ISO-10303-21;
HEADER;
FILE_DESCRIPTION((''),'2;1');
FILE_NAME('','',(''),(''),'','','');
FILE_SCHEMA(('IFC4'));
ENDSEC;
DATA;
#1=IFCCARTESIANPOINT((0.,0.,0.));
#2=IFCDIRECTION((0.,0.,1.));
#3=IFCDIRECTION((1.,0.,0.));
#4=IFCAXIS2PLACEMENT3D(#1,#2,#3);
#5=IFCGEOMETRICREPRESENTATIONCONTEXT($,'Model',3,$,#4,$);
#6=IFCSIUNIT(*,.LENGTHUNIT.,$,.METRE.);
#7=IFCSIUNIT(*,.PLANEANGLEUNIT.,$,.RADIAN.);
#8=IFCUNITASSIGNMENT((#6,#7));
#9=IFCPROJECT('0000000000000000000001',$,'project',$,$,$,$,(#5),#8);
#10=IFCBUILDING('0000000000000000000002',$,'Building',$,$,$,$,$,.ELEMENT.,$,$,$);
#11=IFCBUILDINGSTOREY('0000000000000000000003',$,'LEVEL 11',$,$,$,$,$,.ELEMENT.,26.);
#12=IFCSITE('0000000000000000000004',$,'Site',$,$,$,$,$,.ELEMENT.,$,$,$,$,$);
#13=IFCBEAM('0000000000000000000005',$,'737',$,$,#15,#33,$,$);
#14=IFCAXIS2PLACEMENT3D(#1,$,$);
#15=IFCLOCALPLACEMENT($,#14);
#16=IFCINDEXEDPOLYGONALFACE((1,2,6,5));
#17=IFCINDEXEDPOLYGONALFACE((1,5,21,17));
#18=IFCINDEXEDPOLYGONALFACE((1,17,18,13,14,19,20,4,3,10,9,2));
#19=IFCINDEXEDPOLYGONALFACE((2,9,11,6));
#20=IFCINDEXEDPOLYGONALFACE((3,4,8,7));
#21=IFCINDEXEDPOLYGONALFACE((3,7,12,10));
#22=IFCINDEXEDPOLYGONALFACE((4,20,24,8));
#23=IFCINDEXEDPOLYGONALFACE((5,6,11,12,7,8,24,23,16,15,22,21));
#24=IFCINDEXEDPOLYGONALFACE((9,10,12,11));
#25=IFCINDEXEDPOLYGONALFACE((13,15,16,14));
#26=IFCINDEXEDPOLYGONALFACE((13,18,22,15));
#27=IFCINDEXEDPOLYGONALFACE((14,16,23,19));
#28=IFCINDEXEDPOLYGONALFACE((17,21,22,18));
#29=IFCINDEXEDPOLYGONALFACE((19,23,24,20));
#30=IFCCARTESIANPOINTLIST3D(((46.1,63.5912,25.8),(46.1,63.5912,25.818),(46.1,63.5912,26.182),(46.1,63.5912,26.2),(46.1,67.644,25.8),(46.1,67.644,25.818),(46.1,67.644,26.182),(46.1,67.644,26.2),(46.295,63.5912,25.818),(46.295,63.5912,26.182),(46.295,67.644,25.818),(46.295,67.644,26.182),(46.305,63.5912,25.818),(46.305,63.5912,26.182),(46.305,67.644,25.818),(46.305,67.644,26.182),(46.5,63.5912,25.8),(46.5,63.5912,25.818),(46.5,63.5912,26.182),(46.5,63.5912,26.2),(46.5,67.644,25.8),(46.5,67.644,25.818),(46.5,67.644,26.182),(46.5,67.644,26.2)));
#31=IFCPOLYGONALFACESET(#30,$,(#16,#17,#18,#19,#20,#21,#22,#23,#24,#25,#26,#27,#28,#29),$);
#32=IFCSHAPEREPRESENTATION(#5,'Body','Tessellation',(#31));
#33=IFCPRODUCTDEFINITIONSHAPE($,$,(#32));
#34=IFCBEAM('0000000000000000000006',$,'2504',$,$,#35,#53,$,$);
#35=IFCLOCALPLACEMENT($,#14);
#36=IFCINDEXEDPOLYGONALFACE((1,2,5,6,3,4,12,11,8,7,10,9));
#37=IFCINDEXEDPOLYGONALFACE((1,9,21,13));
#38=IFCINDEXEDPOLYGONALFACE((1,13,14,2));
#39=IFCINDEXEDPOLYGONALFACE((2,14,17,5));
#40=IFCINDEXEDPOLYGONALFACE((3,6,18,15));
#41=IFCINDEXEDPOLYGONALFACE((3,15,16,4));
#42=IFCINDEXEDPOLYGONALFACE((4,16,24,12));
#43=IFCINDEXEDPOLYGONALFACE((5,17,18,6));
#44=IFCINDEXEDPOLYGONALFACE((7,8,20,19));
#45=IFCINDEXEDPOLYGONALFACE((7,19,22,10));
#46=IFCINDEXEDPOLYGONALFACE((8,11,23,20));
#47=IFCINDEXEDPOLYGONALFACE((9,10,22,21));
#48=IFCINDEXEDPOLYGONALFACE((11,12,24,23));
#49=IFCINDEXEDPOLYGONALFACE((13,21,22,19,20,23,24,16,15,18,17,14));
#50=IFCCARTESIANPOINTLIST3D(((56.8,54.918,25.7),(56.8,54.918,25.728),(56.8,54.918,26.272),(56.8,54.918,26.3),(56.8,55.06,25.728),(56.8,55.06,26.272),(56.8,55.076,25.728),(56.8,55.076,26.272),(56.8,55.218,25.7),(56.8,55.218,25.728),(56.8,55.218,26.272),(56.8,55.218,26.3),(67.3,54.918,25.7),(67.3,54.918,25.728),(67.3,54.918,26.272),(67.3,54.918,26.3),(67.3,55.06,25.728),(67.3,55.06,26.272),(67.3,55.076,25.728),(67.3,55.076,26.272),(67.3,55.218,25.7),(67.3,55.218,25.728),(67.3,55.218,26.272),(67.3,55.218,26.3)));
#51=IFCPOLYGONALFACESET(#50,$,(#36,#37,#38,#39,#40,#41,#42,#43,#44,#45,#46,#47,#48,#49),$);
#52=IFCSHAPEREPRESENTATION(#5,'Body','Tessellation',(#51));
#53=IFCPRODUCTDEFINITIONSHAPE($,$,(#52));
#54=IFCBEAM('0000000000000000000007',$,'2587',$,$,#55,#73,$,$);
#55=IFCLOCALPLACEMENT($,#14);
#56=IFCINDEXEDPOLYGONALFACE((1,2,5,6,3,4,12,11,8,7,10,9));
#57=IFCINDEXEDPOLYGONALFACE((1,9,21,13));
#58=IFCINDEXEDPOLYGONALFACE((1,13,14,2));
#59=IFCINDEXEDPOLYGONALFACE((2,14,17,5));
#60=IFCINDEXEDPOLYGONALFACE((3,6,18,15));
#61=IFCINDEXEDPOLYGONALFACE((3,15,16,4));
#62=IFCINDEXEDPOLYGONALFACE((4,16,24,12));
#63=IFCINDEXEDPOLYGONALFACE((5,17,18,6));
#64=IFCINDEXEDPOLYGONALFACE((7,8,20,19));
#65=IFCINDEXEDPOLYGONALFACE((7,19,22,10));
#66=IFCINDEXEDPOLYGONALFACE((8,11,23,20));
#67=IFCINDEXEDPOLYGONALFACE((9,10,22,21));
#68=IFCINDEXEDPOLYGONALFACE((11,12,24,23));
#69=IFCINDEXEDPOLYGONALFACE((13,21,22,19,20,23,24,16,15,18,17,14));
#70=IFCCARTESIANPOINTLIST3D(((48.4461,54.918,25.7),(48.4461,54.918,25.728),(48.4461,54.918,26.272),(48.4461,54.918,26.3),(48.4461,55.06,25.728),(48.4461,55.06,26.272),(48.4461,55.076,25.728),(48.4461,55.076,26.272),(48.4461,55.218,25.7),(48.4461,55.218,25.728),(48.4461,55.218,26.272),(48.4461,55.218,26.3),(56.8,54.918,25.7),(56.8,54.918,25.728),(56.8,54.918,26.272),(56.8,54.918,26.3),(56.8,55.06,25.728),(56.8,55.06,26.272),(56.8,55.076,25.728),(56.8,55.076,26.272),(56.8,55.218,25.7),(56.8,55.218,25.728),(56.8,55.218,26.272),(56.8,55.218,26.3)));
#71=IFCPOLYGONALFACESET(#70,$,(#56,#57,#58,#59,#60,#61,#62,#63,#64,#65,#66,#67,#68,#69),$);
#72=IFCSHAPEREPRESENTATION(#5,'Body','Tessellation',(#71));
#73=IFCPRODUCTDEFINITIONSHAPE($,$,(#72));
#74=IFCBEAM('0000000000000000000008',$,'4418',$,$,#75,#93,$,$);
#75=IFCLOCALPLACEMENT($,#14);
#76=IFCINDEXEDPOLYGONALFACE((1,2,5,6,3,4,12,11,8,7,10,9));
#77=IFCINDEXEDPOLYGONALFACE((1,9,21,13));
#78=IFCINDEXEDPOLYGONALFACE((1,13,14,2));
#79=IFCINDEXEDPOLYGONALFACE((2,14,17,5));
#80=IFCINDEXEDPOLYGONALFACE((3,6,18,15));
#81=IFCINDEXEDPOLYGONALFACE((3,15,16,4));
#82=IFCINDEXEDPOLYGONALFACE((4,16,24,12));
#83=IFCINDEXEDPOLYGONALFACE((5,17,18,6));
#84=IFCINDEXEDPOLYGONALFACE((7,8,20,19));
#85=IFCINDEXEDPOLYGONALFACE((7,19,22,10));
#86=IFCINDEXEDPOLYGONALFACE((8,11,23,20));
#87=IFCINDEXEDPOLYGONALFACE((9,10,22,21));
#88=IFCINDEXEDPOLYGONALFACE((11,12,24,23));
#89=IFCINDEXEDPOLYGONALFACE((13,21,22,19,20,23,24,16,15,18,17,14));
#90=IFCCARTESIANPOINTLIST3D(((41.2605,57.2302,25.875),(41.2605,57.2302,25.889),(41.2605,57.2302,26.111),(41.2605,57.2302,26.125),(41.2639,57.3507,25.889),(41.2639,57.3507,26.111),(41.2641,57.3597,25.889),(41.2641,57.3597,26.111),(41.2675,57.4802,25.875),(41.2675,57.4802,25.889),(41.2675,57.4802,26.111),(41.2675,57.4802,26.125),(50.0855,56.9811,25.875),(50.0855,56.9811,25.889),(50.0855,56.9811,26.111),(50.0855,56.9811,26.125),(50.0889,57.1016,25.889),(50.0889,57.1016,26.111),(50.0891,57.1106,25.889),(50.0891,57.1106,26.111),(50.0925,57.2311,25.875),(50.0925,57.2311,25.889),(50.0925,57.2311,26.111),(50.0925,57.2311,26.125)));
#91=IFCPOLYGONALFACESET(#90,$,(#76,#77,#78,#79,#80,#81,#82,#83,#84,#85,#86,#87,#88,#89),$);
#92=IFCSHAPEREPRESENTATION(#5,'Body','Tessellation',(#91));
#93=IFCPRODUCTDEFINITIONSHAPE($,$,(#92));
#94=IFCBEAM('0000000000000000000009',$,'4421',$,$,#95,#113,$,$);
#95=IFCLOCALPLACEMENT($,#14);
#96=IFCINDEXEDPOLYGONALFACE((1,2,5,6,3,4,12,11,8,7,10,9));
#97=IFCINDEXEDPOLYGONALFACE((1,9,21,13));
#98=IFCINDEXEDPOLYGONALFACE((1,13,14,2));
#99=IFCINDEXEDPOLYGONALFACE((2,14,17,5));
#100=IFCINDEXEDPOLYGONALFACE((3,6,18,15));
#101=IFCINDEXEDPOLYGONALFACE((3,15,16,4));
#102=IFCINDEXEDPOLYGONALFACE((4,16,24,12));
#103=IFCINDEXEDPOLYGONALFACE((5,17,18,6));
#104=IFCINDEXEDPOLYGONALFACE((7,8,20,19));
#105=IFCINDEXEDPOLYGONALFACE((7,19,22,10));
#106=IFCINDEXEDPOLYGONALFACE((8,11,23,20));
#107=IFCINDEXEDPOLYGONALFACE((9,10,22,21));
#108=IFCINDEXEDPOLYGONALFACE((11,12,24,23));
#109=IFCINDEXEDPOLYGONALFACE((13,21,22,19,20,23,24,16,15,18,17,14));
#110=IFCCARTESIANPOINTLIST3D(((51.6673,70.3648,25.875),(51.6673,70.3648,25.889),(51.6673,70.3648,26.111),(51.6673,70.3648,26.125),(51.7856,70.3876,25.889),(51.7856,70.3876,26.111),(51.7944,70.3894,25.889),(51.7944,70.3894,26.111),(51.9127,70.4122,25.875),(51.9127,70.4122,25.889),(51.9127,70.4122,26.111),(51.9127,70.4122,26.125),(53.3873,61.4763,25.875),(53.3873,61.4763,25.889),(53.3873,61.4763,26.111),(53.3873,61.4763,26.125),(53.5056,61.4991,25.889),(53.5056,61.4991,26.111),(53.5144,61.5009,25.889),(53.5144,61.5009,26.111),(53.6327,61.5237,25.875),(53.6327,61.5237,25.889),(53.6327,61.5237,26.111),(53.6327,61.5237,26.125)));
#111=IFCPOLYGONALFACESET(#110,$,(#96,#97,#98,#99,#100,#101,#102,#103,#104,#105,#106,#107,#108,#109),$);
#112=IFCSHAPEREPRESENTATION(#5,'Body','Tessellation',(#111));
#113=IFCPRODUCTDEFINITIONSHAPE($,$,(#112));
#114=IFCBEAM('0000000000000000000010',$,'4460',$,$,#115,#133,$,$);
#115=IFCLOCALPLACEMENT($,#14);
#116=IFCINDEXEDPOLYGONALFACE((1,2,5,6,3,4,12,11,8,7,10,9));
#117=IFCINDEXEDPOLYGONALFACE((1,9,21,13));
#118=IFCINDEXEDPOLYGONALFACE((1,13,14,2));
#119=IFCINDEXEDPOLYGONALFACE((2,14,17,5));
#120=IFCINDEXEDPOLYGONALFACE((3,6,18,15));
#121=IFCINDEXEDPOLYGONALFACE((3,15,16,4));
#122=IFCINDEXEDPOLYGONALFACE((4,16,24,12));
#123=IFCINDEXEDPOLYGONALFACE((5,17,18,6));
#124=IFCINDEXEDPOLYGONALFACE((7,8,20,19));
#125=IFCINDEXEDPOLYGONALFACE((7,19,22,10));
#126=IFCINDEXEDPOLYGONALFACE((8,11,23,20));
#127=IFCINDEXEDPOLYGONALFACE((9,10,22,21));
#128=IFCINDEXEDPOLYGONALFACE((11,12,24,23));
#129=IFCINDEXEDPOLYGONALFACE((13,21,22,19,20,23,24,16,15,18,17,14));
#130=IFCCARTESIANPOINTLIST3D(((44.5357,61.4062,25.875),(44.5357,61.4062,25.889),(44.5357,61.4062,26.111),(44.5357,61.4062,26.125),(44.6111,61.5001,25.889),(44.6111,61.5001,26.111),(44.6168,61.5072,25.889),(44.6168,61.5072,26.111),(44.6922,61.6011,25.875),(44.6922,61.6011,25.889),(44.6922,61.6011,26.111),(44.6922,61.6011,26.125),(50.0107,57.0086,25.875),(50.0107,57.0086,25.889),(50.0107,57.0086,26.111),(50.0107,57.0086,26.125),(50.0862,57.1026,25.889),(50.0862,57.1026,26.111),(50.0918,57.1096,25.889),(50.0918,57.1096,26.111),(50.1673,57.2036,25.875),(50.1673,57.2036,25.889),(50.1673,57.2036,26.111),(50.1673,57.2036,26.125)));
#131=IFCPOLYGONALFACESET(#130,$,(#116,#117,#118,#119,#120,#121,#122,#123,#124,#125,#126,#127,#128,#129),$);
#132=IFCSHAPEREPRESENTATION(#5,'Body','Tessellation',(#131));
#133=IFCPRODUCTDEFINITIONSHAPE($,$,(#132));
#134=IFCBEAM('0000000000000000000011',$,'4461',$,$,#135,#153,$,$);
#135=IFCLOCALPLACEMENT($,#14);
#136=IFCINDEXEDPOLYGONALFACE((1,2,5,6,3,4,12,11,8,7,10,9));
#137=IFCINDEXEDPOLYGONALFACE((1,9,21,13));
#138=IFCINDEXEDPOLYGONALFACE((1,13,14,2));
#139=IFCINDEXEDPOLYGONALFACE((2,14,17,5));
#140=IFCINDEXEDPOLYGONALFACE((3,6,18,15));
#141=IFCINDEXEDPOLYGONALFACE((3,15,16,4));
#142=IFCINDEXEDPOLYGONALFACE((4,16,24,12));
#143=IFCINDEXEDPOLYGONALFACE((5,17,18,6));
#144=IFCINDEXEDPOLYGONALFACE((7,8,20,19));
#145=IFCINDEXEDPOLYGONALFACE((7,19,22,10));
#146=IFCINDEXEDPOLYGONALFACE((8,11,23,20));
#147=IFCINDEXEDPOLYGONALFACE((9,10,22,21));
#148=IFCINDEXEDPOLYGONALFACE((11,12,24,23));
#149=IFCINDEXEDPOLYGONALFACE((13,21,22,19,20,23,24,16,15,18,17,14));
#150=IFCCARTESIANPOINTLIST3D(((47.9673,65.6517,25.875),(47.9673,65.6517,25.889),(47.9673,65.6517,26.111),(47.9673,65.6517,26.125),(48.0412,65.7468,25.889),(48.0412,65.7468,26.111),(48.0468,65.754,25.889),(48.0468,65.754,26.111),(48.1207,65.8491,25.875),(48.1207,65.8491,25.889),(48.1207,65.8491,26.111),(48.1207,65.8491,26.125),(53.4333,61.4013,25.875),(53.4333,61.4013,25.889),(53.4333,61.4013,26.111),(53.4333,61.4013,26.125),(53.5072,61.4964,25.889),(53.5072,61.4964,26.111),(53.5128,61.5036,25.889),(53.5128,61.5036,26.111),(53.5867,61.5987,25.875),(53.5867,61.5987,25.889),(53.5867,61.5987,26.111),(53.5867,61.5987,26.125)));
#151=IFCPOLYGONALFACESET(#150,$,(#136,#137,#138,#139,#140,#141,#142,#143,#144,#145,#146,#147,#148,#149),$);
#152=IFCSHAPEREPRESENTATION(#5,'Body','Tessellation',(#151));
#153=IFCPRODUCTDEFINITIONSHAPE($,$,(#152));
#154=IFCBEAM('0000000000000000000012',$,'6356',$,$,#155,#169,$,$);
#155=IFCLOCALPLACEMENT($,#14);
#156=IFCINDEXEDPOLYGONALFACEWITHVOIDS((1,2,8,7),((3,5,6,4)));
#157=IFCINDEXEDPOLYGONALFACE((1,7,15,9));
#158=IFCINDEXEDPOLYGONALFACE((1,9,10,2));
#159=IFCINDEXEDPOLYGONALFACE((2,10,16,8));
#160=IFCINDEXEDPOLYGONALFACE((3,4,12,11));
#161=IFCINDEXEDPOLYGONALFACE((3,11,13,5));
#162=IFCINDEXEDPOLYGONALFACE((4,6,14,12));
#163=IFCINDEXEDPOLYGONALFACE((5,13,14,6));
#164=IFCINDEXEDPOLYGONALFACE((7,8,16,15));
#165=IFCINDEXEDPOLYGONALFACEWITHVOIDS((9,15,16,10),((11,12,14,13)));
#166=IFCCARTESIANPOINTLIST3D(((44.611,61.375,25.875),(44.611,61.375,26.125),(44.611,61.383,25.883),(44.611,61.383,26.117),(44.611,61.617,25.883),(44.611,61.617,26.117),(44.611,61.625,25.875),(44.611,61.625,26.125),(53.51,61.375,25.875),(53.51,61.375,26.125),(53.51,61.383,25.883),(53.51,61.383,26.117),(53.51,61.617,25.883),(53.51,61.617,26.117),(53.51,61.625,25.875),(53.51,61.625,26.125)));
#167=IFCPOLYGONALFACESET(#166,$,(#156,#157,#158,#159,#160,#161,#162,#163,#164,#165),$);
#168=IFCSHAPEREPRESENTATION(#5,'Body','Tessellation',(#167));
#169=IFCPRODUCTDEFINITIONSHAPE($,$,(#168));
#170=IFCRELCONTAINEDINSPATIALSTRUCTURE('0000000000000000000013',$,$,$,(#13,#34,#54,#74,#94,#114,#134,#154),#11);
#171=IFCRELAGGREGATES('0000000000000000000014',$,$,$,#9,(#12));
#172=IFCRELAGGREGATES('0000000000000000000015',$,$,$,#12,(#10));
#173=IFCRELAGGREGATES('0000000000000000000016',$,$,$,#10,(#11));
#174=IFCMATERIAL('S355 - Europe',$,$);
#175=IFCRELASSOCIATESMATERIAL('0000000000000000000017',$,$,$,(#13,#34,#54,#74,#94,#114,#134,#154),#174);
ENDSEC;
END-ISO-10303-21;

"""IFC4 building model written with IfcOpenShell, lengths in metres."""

from ifc_helpers import new_model, si_unit, frame, origin_with_axes, origin_2d_with_axis, place, context, project, spatial, hollow_rectangle, i_section, extrude, material, material_profile, profile_set, profile_usage, element, save


model = new_model("IFC4")

# Units and contexts
model_context = context("Model", 3, world=origin_with_axes())
ifc_project = project(units=[si_unit("LENGTHUNIT", "METRE"), si_unit("PLANEANGLEUNIT", "RADIAN")], contexts=[model_context])

# Site, building, storey
site = spatial("IfcSite", under=ifc_project, Name="Site", CompositionType="ELEMENT")
building = spatial("IfcBuilding", under=site, Name="Building", CompositionType="ELEMENT")
storey = spatial("IfcBuildingStorey", under=building, Name="LEVEL 11", CompositionType="ELEMENT", Elevation=26.0)

# Shared definitions
ifc_material = material(Name="S355 - Europe")

# Beams
ifc_material_profile_1 = material_profile(ifc_material, i_section(OverallWidth=0.4, OverallDepth=0.4, WebThickness=0.01, FlangeThickness=0.018, at=origin_2d_with_axis()))
ifc_profile_set_1 = profile_set([ifc_material_profile_1])
ifc_profile_usage_1 = profile_usage(ifc_profile_set_1, cardinal=10)
beam_1_placement = place(None, frame((46.3, 63.5912, 26.0), z_axis=(0.0, 1.0, 0.0), x_axis=(-1.0, 0.0, 0.0)))
element("IfcBeam", 1, at=beam_1_placement, inside=storey, material=ifc_profile_usage_1, Name="737", context=model_context, shape_type="SweptSolid", body=[
    extrude(i_section(OverallWidth=0.4, OverallDepth=0.4, WebThickness=0.01, FlangeThickness=0.018, at=origin_2d_with_axis()), origin_with_axes(), (0.0, 0.0, 1.0), 4.0528),
])
ifc_material_profile_2 = material_profile(ifc_material, i_section(OverallWidth=0.3, OverallDepth=0.6, WebThickness=0.016, FlangeThickness=0.028, at=origin_2d_with_axis()))
ifc_profile_set_2 = profile_set([ifc_material_profile_2])
ifc_profile_usage_2 = profile_usage(ifc_profile_set_2, cardinal=10)
beam_2_placement = place(None, frame((56.8, 55.068, 26.0), z_axis=(1.0, 0.0, 0.0), x_axis=(0.0, 1.0, 0.0)))
element("IfcBeam", 2, at=beam_2_placement, inside=storey, material=ifc_profile_usage_2, Name="2504", context=model_context, shape_type="SweptSolid", body=[
    extrude(i_section(OverallWidth=0.3, OverallDepth=0.6, WebThickness=0.016, FlangeThickness=0.028, at=origin_2d_with_axis()), origin_with_axes(), (0.0, 0.0, 1.0), 10.5),
])
ifc_material_profile_3 = material_profile(ifc_material, i_section(OverallWidth=0.3, OverallDepth=0.6, WebThickness=0.016, FlangeThickness=0.028, at=origin_2d_with_axis()))
ifc_profile_set_3 = profile_set([ifc_material_profile_3])
ifc_profile_usage_3 = profile_usage(ifc_profile_set_3, cardinal=10)
beam_3_placement = place(None, frame((48.4461, 55.068, 26.0), z_axis=(1.0, 0.0, 0.0), x_axis=(0.0, 1.0, 0.0)))
element("IfcBeam", 3, at=beam_3_placement, inside=storey, material=ifc_profile_usage_3, Name="2587", context=model_context, shape_type="SweptSolid", body=[
    extrude(i_section(OverallWidth=0.3, OverallDepth=0.6, WebThickness=0.016, FlangeThickness=0.028, at=origin_2d_with_axis()), origin_with_axes(), (0.0, 0.0, 1.0), 8.3539),
])
ifc_material_profile_4 = material_profile(ifc_material, i_section(OverallWidth=0.25, OverallDepth=0.25, WebThickness=0.009, FlangeThickness=0.014, at=origin_2d_with_axis()))
ifc_profile_set_4 = profile_set([ifc_material_profile_4])
ifc_profile_usage_4 = profile_usage(ifc_profile_set_4, cardinal=10)
beam_4_placement = place(None, frame((41.264, 57.3552, 26.0), z_axis=(0.999602, -0.028215, 0.0), x_axis=(0.028215, 0.999602, 0.0)))
element("IfcBeam", 4, at=beam_4_placement, inside=storey, material=ifc_profile_usage_4, Name="4418", context=model_context, shape_type="SweptSolid", body=[
    extrude(i_section(OverallWidth=0.25, OverallDepth=0.25, WebThickness=0.009, FlangeThickness=0.014, at=origin_2d_with_axis()), origin_with_axes(), (0.0, 0.0, 1.0), 8.8285),
])
ifc_material_profile_5 = material_profile(ifc_material, i_section(OverallWidth=0.25, OverallDepth=0.25, WebThickness=0.009, FlangeThickness=0.014, at=origin_2d_with_axis()))
ifc_profile_set_5 = profile_set([ifc_material_profile_5])
ifc_profile_usage_5 = profile_usage(ifc_profile_set_5, cardinal=10)
beam_5_placement = place(None, frame((53.51, 61.5, 26.0), z_axis=(-0.189984, 0.981787, 0.0), x_axis=(-0.981787, -0.189984, 0.0)))
element("IfcBeam", 5, at=beam_5_placement, inside=storey, material=ifc_profile_usage_5, Name="4421", context=model_context, shape_type="SweptSolid", body=[
    extrude(i_section(OverallWidth=0.25, OverallDepth=0.25, WebThickness=0.009, FlangeThickness=0.014, at=origin_2d_with_axis()), origin_with_axes(), (0.0, 0.0, 1.0), 9.0534),
])
ifc_material_profile_6 = material_profile(ifc_material, i_section(OverallWidth=0.25, OverallDepth=0.25, WebThickness=0.009, FlangeThickness=0.014, at=origin_2d_with_axis()))
ifc_profile_set_6 = profile_set([ifc_material_profile_6])
ifc_profile_usage_6 = profile_usage(ifc_profile_set_6, cardinal=10)
beam_6_placement = place(None, frame((50.089, 57.1061, 26.0), z_axis=(-0.779651, 0.626214, 0.0), x_axis=(-0.626214, -0.779651, 0.0)))
element("IfcBeam", 6, at=beam_6_placement, inside=storey, material=ifc_profile_usage_6, Name="4460", context=model_context, shape_type="SweptSolid", body=[
    extrude(i_section(OverallWidth=0.25, OverallDepth=0.25, WebThickness=0.009, FlangeThickness=0.014, at=origin_2d_with_axis()), origin_with_axes(), (0.0, 0.0, 1.0), 7.0225),
])
ifc_material_profile_7 = material_profile(ifc_material, i_section(OverallWidth=0.25, OverallDepth=0.25, WebThickness=0.009, FlangeThickness=0.014, at=origin_2d_with_axis()))
ifc_profile_set_7 = profile_set([ifc_material_profile_7])
ifc_profile_usage_7 = profile_usage(ifc_profile_set_7, cardinal=10)
beam_7_placement = place(None, frame((53.51, 61.5, 26.0), z_axis=(-0.789418, 0.613857, 0.0), x_axis=(-0.613857, -0.789418, 0.0)))
element("IfcBeam", 7, at=beam_7_placement, inside=storey, material=ifc_profile_usage_7, Name="4461", context=model_context, shape_type="SweptSolid", body=[
    extrude(i_section(OverallWidth=0.25, OverallDepth=0.25, WebThickness=0.009, FlangeThickness=0.014, at=origin_2d_with_axis()), origin_with_axes(), (0.0, 0.0, 1.0), 6.9241),
])
ifc_material_profile_8 = material_profile(ifc_material, hollow_rectangle(XDim=0.25, YDim=0.25, WallThickness=0.008, at=origin_2d_with_axis()))
ifc_profile_set_8 = profile_set([ifc_material_profile_8])
ifc_profile_usage_8 = profile_usage(ifc_profile_set_8, cardinal=10)
beam_8_placement = place(None, frame((44.611, 61.5, 26.0), z_axis=(1.0, 0.0, 0.0), x_axis=(0.0, 1.0, 0.0)))
element("IfcBeam", 8, at=beam_8_placement, inside=storey, material=ifc_profile_usage_8, Name="6356", context=model_context, shape_type="SweptSolid", body=[
    extrude(hollow_rectangle(XDim=0.25, YDim=0.25, WallThickness=0.008, at=origin_2d_with_axis()), origin_with_axes(), (0.0, 0.0, 1.0), 8.899),
])

save(model, "model.ifc")
